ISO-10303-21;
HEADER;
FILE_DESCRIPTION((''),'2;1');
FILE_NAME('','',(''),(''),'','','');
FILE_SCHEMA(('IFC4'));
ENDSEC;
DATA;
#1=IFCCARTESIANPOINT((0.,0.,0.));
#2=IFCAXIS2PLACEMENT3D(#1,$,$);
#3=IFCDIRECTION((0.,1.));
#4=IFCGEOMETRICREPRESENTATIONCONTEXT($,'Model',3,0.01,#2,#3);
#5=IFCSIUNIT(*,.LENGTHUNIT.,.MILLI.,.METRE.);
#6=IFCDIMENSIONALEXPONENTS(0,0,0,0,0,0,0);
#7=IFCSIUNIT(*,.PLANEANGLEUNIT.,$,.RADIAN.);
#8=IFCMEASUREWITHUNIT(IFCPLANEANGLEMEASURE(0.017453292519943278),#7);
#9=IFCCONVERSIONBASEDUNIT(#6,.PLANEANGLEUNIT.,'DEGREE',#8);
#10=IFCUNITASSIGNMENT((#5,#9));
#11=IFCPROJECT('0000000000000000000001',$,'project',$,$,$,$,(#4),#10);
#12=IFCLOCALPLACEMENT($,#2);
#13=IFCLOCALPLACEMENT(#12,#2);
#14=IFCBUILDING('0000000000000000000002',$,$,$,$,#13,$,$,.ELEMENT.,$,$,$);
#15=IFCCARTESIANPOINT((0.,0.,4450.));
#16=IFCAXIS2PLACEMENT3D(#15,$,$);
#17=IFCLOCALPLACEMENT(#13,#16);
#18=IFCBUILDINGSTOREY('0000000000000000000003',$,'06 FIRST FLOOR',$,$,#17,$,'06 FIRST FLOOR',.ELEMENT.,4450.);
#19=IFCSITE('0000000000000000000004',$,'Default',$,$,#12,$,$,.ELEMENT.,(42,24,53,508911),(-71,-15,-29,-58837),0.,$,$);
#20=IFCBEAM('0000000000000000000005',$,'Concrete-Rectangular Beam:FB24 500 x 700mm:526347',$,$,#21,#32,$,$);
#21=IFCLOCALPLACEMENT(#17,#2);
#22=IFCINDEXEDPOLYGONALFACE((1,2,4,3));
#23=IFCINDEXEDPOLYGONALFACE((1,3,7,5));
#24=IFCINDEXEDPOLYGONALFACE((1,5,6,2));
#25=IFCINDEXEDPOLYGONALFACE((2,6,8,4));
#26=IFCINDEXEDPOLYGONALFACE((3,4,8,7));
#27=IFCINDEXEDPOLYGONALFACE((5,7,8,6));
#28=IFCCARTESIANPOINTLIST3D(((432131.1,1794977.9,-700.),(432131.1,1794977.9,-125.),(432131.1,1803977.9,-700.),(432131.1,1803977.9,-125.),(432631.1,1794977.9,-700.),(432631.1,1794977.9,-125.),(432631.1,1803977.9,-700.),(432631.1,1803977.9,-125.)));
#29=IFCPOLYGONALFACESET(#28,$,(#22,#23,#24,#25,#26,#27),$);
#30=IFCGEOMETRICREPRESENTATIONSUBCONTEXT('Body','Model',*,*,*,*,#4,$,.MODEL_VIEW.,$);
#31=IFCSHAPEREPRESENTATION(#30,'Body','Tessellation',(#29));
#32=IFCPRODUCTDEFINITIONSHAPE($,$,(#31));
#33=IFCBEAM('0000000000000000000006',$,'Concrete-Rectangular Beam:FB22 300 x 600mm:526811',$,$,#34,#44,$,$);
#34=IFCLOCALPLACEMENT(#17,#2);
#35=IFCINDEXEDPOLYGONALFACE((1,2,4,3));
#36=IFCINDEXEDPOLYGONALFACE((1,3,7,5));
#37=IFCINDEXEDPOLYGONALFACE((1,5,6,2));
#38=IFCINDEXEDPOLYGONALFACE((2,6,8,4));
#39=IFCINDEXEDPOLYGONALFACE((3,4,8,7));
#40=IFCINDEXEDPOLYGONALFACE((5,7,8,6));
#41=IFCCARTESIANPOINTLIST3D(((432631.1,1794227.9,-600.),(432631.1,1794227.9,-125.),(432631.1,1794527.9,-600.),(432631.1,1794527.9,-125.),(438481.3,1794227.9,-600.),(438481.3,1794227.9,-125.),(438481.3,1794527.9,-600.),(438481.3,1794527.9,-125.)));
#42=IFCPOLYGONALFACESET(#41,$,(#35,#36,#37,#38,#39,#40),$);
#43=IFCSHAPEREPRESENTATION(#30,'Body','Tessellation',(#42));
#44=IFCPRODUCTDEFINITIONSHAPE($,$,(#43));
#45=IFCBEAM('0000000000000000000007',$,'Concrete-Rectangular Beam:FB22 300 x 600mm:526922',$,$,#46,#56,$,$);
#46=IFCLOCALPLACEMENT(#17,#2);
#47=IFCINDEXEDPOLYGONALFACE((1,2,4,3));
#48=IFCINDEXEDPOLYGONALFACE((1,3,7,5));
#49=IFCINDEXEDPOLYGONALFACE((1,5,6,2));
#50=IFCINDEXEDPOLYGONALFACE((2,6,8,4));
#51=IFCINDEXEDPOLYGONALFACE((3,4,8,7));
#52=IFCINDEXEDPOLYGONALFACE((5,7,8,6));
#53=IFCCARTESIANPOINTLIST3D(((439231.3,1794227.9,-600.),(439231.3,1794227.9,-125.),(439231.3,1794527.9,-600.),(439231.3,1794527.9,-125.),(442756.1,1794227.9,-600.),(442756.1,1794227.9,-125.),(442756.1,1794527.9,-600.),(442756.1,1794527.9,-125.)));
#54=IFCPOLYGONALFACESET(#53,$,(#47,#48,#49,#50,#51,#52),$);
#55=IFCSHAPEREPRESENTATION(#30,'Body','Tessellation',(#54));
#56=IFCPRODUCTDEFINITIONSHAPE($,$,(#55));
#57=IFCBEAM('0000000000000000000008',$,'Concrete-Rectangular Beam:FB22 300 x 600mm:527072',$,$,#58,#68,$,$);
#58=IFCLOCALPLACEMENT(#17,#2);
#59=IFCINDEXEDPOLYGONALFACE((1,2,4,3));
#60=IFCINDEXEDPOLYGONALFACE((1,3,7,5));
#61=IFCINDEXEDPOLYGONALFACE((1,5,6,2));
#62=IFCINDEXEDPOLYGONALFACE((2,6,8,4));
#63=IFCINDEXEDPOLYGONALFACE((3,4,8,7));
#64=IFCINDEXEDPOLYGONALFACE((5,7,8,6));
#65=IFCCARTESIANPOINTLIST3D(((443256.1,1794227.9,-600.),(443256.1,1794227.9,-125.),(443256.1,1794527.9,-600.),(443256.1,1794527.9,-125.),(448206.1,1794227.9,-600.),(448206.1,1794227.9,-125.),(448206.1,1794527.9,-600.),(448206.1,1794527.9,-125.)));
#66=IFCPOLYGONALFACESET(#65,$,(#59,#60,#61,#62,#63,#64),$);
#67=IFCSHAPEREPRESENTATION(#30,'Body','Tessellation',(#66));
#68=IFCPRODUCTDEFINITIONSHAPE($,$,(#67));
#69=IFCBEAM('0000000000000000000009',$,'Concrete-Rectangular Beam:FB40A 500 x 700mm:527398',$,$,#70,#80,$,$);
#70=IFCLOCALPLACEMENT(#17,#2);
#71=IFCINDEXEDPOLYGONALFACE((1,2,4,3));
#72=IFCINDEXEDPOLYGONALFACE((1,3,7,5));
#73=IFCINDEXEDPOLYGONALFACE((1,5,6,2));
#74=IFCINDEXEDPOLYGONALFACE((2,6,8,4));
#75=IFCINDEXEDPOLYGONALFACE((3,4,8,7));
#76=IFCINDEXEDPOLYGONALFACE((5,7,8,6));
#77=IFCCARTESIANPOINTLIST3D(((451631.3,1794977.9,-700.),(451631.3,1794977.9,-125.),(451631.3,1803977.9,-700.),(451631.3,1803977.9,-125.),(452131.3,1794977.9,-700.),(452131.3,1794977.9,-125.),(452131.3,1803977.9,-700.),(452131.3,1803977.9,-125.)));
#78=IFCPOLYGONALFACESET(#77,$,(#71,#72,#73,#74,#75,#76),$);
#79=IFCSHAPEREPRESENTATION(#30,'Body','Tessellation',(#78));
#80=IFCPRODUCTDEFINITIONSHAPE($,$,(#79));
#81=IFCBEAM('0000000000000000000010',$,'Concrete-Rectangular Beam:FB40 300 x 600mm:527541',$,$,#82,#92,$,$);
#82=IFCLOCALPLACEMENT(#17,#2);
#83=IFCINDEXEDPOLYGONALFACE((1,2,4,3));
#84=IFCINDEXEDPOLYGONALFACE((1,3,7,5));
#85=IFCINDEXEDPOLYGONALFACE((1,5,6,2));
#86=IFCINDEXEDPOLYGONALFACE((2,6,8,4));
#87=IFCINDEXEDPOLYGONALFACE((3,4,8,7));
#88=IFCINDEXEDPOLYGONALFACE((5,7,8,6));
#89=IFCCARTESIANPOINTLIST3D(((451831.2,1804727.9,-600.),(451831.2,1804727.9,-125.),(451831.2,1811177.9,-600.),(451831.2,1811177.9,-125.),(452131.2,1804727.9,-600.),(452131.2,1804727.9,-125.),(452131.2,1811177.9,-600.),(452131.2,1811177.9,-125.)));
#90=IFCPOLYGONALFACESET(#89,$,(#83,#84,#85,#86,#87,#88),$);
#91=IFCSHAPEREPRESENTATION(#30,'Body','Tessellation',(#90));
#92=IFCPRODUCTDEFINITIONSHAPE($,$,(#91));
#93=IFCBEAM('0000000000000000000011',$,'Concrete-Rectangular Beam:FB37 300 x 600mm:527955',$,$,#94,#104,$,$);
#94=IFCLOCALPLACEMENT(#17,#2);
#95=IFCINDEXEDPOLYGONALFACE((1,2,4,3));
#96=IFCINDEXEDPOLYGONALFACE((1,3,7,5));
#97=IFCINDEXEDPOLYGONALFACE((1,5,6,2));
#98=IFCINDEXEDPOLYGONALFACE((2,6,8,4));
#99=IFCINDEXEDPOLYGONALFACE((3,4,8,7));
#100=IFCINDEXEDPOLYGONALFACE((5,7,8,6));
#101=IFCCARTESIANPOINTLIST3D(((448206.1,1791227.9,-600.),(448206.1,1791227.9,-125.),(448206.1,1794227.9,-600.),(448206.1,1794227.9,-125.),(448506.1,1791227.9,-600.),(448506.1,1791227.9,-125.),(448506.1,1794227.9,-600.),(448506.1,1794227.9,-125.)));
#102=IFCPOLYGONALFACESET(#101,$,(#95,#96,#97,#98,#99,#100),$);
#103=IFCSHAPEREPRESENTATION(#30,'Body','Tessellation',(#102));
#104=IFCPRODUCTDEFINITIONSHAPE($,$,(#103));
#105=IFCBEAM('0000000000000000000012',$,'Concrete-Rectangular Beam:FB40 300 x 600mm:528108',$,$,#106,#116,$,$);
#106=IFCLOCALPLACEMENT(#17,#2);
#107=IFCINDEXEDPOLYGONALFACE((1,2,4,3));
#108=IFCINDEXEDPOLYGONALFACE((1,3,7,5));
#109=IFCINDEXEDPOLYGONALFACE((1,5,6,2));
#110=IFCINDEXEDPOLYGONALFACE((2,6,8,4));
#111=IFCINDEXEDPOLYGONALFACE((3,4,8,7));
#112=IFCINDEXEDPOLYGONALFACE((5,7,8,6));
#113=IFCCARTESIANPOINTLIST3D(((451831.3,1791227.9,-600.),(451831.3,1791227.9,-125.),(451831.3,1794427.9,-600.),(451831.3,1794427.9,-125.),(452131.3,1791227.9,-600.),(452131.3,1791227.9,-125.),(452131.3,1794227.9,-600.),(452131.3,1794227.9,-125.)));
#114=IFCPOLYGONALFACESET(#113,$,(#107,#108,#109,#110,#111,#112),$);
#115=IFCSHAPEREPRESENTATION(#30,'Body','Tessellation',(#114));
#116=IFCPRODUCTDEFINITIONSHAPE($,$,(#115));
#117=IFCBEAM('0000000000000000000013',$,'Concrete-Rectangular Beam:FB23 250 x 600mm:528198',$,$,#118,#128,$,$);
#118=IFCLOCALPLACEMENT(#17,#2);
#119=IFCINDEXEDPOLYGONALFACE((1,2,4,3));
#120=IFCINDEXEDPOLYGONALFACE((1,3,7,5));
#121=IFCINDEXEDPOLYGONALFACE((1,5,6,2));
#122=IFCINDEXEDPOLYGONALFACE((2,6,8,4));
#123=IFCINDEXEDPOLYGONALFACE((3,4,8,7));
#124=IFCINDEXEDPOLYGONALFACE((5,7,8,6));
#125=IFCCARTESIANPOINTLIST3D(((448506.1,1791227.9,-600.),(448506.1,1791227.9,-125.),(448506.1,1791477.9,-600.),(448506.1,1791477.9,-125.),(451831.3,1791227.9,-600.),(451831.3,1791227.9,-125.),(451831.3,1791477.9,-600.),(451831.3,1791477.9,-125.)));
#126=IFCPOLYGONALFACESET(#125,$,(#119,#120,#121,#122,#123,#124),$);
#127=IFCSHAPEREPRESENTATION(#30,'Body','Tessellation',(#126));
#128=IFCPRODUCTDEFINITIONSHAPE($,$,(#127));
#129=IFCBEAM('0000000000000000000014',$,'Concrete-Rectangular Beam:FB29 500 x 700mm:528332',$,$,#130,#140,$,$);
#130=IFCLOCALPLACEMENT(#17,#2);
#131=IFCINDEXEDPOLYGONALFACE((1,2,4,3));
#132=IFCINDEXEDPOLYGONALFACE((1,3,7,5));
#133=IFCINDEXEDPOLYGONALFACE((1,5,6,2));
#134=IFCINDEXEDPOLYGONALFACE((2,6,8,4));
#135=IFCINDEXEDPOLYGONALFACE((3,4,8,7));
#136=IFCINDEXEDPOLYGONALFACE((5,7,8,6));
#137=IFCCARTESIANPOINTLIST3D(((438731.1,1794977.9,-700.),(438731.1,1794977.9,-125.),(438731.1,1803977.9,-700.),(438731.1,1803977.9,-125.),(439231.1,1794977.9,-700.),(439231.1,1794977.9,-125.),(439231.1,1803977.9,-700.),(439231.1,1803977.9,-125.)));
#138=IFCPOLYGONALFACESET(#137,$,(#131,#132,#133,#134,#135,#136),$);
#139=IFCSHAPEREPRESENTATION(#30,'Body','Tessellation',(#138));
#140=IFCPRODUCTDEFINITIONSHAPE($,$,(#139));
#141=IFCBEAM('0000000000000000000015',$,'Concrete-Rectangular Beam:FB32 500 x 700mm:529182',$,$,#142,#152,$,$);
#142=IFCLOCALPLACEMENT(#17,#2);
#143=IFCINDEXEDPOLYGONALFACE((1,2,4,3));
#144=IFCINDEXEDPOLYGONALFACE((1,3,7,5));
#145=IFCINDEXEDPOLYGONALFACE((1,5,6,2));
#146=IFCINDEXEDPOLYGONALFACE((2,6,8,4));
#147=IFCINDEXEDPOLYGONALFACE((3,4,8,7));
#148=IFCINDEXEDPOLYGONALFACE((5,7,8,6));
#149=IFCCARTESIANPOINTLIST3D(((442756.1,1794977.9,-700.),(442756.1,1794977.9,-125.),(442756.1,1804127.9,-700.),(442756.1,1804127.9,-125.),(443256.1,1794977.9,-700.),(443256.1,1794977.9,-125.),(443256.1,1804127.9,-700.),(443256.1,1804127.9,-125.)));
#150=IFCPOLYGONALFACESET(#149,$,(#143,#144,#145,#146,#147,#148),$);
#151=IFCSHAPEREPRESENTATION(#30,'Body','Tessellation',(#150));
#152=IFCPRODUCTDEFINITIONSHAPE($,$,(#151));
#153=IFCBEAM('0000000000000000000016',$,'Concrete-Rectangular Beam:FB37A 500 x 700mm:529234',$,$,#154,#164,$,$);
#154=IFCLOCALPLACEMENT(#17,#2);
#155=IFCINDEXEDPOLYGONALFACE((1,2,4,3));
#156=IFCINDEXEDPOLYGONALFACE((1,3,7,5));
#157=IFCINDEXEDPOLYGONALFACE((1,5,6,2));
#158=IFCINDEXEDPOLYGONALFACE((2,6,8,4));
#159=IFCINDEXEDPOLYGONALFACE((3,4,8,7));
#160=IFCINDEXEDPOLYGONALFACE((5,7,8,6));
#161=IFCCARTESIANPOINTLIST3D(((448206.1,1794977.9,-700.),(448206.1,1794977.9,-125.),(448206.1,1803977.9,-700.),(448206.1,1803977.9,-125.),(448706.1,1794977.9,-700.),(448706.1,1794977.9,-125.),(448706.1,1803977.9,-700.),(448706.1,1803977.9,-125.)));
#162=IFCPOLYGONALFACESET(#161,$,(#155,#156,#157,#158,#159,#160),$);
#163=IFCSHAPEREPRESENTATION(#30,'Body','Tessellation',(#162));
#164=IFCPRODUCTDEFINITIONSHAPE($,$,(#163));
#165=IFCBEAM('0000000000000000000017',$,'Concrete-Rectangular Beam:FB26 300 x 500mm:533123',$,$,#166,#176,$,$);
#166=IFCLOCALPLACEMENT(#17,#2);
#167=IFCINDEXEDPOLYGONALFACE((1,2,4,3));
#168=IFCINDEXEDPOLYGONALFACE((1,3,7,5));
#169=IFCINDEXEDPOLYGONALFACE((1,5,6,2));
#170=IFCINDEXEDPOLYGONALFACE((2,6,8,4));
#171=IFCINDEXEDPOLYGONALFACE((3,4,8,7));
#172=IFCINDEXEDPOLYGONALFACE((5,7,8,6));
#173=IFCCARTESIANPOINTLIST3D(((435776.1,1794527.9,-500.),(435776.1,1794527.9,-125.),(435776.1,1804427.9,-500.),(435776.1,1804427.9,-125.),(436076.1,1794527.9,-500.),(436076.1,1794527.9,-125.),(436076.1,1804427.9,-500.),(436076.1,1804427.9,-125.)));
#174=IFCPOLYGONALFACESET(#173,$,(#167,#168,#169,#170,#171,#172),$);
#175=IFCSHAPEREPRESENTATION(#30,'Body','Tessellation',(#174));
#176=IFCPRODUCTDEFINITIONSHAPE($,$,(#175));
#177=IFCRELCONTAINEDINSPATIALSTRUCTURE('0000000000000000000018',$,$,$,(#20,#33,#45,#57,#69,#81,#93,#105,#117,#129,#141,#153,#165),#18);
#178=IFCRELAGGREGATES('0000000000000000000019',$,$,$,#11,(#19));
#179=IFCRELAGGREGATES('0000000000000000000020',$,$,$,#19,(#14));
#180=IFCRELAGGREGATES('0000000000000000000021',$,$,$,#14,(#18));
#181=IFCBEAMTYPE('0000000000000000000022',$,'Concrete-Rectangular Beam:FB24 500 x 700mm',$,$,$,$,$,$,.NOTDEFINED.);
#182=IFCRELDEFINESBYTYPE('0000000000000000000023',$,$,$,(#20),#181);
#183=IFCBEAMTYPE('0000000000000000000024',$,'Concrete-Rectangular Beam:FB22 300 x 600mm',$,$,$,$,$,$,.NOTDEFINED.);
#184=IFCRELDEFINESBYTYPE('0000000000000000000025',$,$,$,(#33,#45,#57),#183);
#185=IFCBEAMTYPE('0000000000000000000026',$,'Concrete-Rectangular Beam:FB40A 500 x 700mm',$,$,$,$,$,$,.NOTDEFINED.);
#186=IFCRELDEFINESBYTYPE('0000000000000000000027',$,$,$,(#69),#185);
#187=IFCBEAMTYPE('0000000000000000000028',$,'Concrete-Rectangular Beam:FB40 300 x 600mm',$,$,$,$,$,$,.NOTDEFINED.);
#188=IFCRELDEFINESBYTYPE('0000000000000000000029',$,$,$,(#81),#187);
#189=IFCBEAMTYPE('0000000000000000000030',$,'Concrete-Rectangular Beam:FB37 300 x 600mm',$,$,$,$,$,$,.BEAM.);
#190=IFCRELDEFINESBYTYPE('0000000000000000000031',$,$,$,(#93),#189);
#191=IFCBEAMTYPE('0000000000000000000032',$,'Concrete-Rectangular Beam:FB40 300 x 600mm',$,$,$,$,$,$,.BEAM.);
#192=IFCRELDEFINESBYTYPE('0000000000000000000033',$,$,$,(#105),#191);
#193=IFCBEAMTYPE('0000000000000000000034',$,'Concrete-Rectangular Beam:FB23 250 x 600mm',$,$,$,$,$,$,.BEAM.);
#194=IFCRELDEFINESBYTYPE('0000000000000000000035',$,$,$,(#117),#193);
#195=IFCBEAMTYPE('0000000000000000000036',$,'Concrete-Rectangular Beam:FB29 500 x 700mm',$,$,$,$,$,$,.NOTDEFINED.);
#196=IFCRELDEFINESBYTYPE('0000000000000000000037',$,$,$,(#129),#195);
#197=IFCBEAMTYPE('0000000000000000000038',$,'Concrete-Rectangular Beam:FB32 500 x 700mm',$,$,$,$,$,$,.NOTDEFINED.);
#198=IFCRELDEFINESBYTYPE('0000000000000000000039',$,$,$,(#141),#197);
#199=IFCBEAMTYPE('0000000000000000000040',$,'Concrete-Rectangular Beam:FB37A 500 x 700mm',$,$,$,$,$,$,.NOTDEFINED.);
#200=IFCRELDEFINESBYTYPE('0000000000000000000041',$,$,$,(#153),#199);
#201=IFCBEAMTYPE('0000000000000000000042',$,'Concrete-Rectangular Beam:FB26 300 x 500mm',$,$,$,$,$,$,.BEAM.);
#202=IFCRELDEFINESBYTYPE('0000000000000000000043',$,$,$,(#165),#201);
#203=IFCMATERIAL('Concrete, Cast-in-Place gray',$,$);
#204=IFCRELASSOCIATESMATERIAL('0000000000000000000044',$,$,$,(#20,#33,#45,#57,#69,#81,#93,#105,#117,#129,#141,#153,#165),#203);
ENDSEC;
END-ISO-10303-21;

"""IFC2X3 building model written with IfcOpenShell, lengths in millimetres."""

from ifc_helpers import new_model, entity, si_unit, converted_unit, direction, frame, frame_2d, origin, origin_2d_with_axis, place, context, subcontext, project, spatial, rectangle, extrude, clip, halfspace, material, type_object, element, save


model = new_model("IFC2X3")

# Units and contexts
model_context = context("Model", 3, precision=0.01, world=origin(), true_north=direction((0.0, 1.0)))
body_context = subcontext(model_context, "Body", "Model", "MODEL_VIEW")
ifc_project = project(units=[si_unit("LENGTHUNIT", "METRE", prefix="MILLI"), converted_unit("PLANEANGLEUNIT", "DEGREE", entity("IfcPlaneAngleMeasure", 0.017453292519943278), si_unit("PLANEANGLEUNIT", "RADIAN"), dimensions=[0, 0, 0, 0, 0, 0, 0])], contexts=[model_context])

# Site, building, storey
site_placement = place(None, origin())
site = spatial("IfcSite", under=ifc_project, at=site_placement, Name="Default", CompositionType="ELEMENT", RefLatitude=(42, 24, 53, 508911), RefLongitude=(-71, -15, -29, -58837), RefElevation=0.0)
building_placement = place(site_placement, origin())
building = spatial("IfcBuilding", under=site, at=building_placement, CompositionType="ELEMENT")
storey_placement = place(building_placement, frame((0.0, 0.0, 4450.0)))
storey = spatial("IfcBuildingStorey", under=building, at=storey_placement, Name="06 FIRST FLOOR", LongName="06 FIRST FLOOR", CompositionType="ELEMENT", Elevation=4450.0)

# Beams
ifc_material_1 = material(Name="Concrete, Cast-in-Place gray")
beam_type_1 = type_object("IfcBeamType", Name="Concrete-Rectangular Beam:FB24 500 x 700mm", PredefinedType="NOTDEFINED")
beam_1_placement = place(storey_placement, frame((432631.1, 1794977.9, 0.0), z_axis=(0.0, 0.0, 1.0), x_axis=(0.0, 1.0, 0.0)))
element("IfcBeam", 1, at=beam_1_placement, inside=storey, type_object=beam_type_1, material=ifc_material_1, Name="Concrete-Rectangular Beam:FB24 500 x 700mm:526347", context=body_context, shape_type="SweptSolid", body=[
    extrude(rectangle(XDim=575.0, YDim=500.0, at=frame_2d((0.0, 0.0), x_axis=(1.0, 0.0))), frame((0.0, 250.0, -412.5), z_axis=(1.0, 0.0, 0.0), x_axis=(0.0, 0.0, -1.0)), (0.0, 0.0, 1.0), 9000.0),
])
beam_type_2 = type_object("IfcBeamType", Name="Concrete-Rectangular Beam:FB22 300 x 600mm", PredefinedType="NOTDEFINED")
beam_2_placement = place(storey_placement, frame((432631.1, 1794527.9, 0.0)))
element("IfcBeam", 2, at=beam_2_placement, inside=storey, type_object=beam_type_2, material=ifc_material_1, Name="Concrete-Rectangular Beam:FB22 300 x 600mm:526811", context=body_context, shape_type="SweptSolid", body=[
    extrude(rectangle(XDim=475.0, YDim=300.0, at=origin_2d_with_axis()), frame((0.0, -150.0, -362.5), z_axis=(1.0, 0.0, 0.0), x_axis=(0.0, 0.0, -1.0)), (0.0, 0.0, 1.0), 5850.2),
])
beam_3_placement = place(storey_placement, frame((439231.1, 1794527.9, 0.0)))
element("IfcBeam", 3, at=beam_3_placement, inside=storey, type_object=beam_type_2, material=ifc_material_1, Name="Concrete-Rectangular Beam:FB22 300 x 600mm:526922", context=body_context, shape_type="SweptSolid", body=[
    extrude(rectangle(XDim=475.0, YDim=300.0, at=origin_2d_with_axis()), frame((0.2, -150.0, -362.5), z_axis=(1.0, 0.0, 0.0), x_axis=(0.0, 0.0, -1.0)), (0.0, 0.0, 1.0), 3524.8),
])
beam_4_placement = place(storey_placement, frame((443256.1, 1794527.9, 0.0)))
element("IfcBeam", 4, at=beam_4_placement, inside=storey, type_object=beam_type_2, material=ifc_material_1, Name="Concrete-Rectangular Beam:FB22 300 x 600mm:527072", context=body_context, shape_type="SweptSolid", body=[
    extrude(rectangle(XDim=475.0, YDim=300.0, at=origin_2d_with_axis()), frame((0.0, -150.0, -362.5), z_axis=(1.0, 0.0, 0.0), x_axis=(0.0, 0.0, -1.0)), (0.0, 0.0, 1.0), 4950.0),
])
beam_type_3 = type_object("IfcBeamType", Name="Concrete-Rectangular Beam:FB40A 500 x 700mm", PredefinedType="NOTDEFINED")
beam_5_placement = place(storey_placement, frame((451631.3, 1794977.9, 0.0), z_axis=(0.0, 0.0, 1.0), x_axis=(0.0, 1.0, 0.0)))
element("IfcBeam", 5, at=beam_5_placement, inside=storey, type_object=beam_type_3, material=ifc_material_1, Name="Concrete-Rectangular Beam:FB40A 500 x 700mm:527398", context=body_context, shape_type="SweptSolid", body=[
    extrude(rectangle(XDim=575.0, YDim=500.0, at=frame_2d((0.0, 0.0), x_axis=(1.0, 0.0))), frame((0.0, -250.0, -412.5), z_axis=(1.0, 0.0, 0.0), x_axis=(0.0, 0.0, -1.0)), (0.0, 0.0, 1.0), 9000.0),
])
beam_type_4 = type_object("IfcBeamType", Name="Concrete-Rectangular Beam:FB40 300 x 600mm", PredefinedType="NOTDEFINED")
beam_6_placement = place(storey_placement, frame((451831.2, 1804727.9, 0.0), z_axis=(0.0, 0.0, 1.0), x_axis=(0.0, 1.0, 0.0)))
element("IfcBeam", 6, at=beam_6_placement, inside=storey, type_object=beam_type_4, material=ifc_material_1, Name="Concrete-Rectangular Beam:FB40 300 x 600mm:527541", context=body_context, shape_type="SweptSolid", body=[
    extrude(rectangle(XDim=475.0, YDim=300.0, at=origin_2d_with_axis()), frame((0.0, -150.0, -362.5), z_axis=(1.0, 0.0, 0.0), x_axis=(0.0, 0.0, -1.0)), (0.0, 0.0, 1.0), 6450.0),
])
beam_type_5 = type_object("IfcBeamType", Name="Concrete-Rectangular Beam:FB37 300 x 600mm", PredefinedType="BEAM")
beam_7_placement = place(storey_placement, frame((448506.1, 1794227.9, 0.0), z_axis=(0.0, 0.0, 1.0), x_axis=(0.0, -1.0, 0.0)))
element("IfcBeam", 7, at=beam_7_placement, inside=storey, type_object=beam_type_5, material=ifc_material_1, Name="Concrete-Rectangular Beam:FB37 300 x 600mm:527955", context=body_context, shape_type="SweptSolid", body=[
    extrude(rectangle(XDim=475.0, YDim=300.0, at=origin_2d_with_axis()), frame((0.0, -150.0, -362.5), z_axis=(1.0, 0.0, 0.0), x_axis=(0.0, 0.0, -1.0)), (0.0, 0.0, 1.0), 3000.0),
])
beam_type_6 = type_object("IfcBeamType", Name="Concrete-Rectangular Beam:FB40 300 x 600mm", PredefinedType="BEAM")
beam_8_placement = place(storey_placement, frame((452131.3, 1794227.9, 0.0), z_axis=(0.0, 0.0, 1.0), x_axis=(0.0, -1.0, 0.0)))
element("IfcBeam", 8, at=beam_8_placement, inside=storey, type_object=beam_type_6, material=ifc_material_1, Name="Concrete-Rectangular Beam:FB40 300 x 600mm:528108", context=body_context, shape_type="Clipping", body=[
    clip(extrude(rectangle(XDim=475.0, YDim=300.0, at=frame_2d((0.0, 0.0), x_axis=(1.0, 0.0))), frame((-200.0, -150.0, -362.5), z_axis=(1.0, 0.0, 0.0), x_axis=(0.0, 0.0, -1.0)), (0.0, 0.0, 1.0), 3200.0), halfspace(frame((0.0, 0.0, 0.0), z_axis=(-0.83205, 0.5547, 0.0), x_axis=(0.5547, 0.83205, 0.0)), False)),
])
beam_type_7 = type_object("IfcBeamType", Name="Concrete-Rectangular Beam:FB23 250 x 600mm", PredefinedType="BEAM")
beam_9_placement = place(storey_placement, frame((448506.1, 1791477.9, 0.0)))
element("IfcBeam", 9, at=beam_9_placement, inside=storey, type_object=beam_type_7, material=ifc_material_1, Name="Concrete-Rectangular Beam:FB23 250 x 600mm:528198", context=body_context, shape_type="SweptSolid", body=[
    extrude(rectangle(XDim=475.0, YDim=250.0, at=frame_2d((0.0, 0.0), x_axis=(1.0, 0.0))), frame((0.0, -125.0, -362.5), z_axis=(1.0, 0.0, 0.0), x_axis=(0.0, 0.0, -1.0)), (0.0, 0.0, 1.0), 3325.2),
])
beam_type_8 = type_object("IfcBeamType", Name="Concrete-Rectangular Beam:FB29 500 x 700mm", PredefinedType="NOTDEFINED")
beam_10_placement = place(storey_placement, frame((438731.1, 1794977.9, 0.0), z_axis=(0.0, 0.0, 1.0), x_axis=(0.0, 1.0, 0.0)))
element("IfcBeam", 10, at=beam_10_placement, inside=storey, type_object=beam_type_8, material=ifc_material_1, Name="Concrete-Rectangular Beam:FB29 500 x 700mm:528332", context=body_context, shape_type="SweptSolid", body=[
    extrude(rectangle(XDim=575.0, YDim=500.0, at=frame_2d((0.0, 0.0), x_axis=(1.0, 0.0))), frame((0.0, -250.0, -412.5), z_axis=(1.0, 0.0, 0.0), x_axis=(0.0, 0.0, -1.0)), (0.0, 0.0, 1.0), 9000.0),
])
beam_type_9 = type_object("IfcBeamType", Name="Concrete-Rectangular Beam:FB32 500 x 700mm", PredefinedType="NOTDEFINED")
beam_11_placement = place(storey_placement, frame((442756.1, 1794977.5, 0.0), z_axis=(0.0, 0.0, 1.0), x_axis=(0.0, 1.0, 0.0)))
element("IfcBeam", 11, at=beam_11_placement, inside=storey, type_object=beam_type_9, material=ifc_material_1, Name="Concrete-Rectangular Beam:FB32 500 x 700mm:529182", context=body_context, shape_type="SweptSolid", body=[
    extrude(rectangle(XDim=575.0, YDim=500.0, at=frame_2d((0.0, 0.0), x_axis=(1.0, 0.0))), frame((0.4, -250.0, -412.5), z_axis=(1.0, 0.0, 0.0), x_axis=(0.0, 0.0, -1.0)), (0.0, 0.0, 1.0), 9150.0),
])
beam_type_10 = type_object("IfcBeamType", Name="Concrete-Rectangular Beam:FB37A 500 x 700mm", PredefinedType="NOTDEFINED")
beam_12_placement = place(storey_placement, frame((448206.1, 1794977.9, 0.0), z_axis=(0.0, 0.0, 1.0), x_axis=(0.0, 1.0, 0.0)))
element("IfcBeam", 12, at=beam_12_placement, inside=storey, type_object=beam_type_10, material=ifc_material_1, Name="Concrete-Rectangular Beam:FB37A 500 x 700mm:529234", context=body_context, shape_type="SweptSolid", body=[
    extrude(rectangle(XDim=575.0, YDim=500.0, at=frame_2d((0.0, 0.0), x_axis=(1.0, 0.0))), frame((0.0, -250.0, -412.5), z_axis=(1.0, 0.0, 0.0), x_axis=(0.0, 0.0, -1.0)), (0.0, 0.0, 1.0), 9000.0),
])
beam_type_11 = type_object("IfcBeamType", Name="Concrete-Rectangular Beam:FB26 300 x 500mm", PredefinedType="BEAM")
beam_13_placement = place(storey_placement, frame((436076.1, 1804427.9, 0.0), z_axis=(0.0, 0.0, 1.0), x_axis=(0.0, -1.0, 0.0)))
element("IfcBeam", 13, at=beam_13_placement, inside=storey, type_object=beam_type_11, material=ifc_material_1, Name="Concrete-Rectangular Beam:FB26 300 x 500mm:533123", context=body_context, shape_type="SweptSolid", body=[
    extrude(rectangle(XDim=375.0, YDim=300.0, at=frame_2d((0.0, 0.0), x_axis=(1.0, 0.0))), frame((0.0, -150.0, -312.5), z_axis=(1.0, 0.0, 0.0), x_axis=(0.0, 0.0, -1.0)), (0.0, 0.0, 1.0), 9900.0),
])

save(model, "model.ifc")
